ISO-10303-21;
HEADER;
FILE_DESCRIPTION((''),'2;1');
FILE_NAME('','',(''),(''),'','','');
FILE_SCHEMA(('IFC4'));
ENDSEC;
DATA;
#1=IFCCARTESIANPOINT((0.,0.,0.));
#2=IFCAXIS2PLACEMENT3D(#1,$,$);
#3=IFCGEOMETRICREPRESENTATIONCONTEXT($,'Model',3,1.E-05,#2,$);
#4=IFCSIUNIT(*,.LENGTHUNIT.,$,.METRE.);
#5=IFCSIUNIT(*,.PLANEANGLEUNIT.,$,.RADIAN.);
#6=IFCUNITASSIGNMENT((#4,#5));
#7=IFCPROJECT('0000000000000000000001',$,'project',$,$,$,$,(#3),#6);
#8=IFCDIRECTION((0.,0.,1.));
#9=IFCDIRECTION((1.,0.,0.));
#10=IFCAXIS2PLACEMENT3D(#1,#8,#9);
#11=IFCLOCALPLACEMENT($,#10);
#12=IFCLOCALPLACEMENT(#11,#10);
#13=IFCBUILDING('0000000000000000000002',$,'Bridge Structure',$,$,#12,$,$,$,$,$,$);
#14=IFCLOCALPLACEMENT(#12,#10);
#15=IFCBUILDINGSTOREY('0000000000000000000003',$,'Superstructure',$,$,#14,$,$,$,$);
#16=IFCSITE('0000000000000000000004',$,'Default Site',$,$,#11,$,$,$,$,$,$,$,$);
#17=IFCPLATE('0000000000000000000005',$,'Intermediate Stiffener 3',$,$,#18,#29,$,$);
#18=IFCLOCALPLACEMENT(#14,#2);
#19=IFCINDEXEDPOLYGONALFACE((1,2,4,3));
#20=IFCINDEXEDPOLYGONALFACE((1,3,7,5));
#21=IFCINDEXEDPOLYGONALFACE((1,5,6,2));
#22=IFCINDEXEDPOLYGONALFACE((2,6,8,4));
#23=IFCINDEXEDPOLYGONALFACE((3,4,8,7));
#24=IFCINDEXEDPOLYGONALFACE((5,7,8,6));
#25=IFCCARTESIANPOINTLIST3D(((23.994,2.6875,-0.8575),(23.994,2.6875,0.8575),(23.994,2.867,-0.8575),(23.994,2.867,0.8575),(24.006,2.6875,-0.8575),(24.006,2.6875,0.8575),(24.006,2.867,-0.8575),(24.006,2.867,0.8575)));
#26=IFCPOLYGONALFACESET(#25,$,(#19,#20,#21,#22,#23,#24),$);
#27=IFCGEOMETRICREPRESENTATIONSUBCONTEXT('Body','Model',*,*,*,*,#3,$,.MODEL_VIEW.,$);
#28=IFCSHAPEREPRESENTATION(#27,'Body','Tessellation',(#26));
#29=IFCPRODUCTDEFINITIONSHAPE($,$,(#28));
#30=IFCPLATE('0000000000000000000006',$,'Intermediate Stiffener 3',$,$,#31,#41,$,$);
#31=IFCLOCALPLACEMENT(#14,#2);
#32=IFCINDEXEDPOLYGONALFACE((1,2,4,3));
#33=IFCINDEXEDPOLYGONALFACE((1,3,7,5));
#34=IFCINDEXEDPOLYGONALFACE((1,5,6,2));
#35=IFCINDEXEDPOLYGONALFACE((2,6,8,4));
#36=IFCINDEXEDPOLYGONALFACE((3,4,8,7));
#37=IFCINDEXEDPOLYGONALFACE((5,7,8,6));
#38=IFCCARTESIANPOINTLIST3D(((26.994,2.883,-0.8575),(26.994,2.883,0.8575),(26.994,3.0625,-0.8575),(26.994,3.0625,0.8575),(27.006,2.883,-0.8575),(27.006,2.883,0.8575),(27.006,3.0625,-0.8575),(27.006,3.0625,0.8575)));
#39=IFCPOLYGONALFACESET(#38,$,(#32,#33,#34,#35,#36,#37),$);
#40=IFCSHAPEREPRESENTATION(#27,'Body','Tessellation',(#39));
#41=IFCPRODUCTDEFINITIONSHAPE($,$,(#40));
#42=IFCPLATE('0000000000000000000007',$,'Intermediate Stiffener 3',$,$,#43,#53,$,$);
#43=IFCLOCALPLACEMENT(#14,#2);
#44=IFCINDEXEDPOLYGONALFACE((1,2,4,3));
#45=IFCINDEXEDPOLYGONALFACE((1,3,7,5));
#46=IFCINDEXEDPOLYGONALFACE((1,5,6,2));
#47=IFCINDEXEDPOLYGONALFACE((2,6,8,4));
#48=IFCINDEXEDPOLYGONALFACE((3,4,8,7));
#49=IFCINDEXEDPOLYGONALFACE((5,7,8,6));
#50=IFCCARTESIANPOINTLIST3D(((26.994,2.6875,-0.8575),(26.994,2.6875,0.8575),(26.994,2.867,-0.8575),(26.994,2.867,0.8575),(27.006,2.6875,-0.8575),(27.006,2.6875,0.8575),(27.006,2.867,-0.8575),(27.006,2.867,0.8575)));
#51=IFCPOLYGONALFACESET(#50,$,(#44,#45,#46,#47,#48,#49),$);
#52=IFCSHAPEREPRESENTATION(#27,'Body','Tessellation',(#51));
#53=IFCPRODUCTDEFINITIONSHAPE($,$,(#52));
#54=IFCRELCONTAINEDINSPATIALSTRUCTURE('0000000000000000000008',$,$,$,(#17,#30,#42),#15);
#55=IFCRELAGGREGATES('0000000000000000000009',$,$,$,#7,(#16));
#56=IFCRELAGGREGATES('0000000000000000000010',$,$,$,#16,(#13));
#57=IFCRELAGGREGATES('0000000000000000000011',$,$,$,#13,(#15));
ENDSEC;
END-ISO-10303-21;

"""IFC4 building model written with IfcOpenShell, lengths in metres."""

from ifc_helpers import new_model, si_unit, frame, origin, origin_with_axes, origin_2d_with_axis, place, context, subcontext, project, spatial, rectangle, extrude, element, save


model = new_model("IFC4")

# Units and contexts
model_context = context("Model", 3, precision=1e-05, world=origin())
body_context = subcontext(model_context, "Body", "Model", "MODEL_VIEW")
ifc_project = project(units=[si_unit("LENGTHUNIT", "METRE"), si_unit("PLANEANGLEUNIT", "RADIAN")], contexts=[model_context])

# Site, building, storey
site_placement = place(None, origin_with_axes())
site = spatial("IfcSite", under=ifc_project, at=site_placement, Name="Default Site")
building_placement = place(site_placement, origin_with_axes())
building = spatial("IfcBuilding", under=site, at=building_placement, Name="Bridge Structure")
storey_placement = place(building_placement, origin_with_axes())
storey = spatial("IfcBuildingStorey", under=building, at=storey_placement, Name="Superstructure")

# Plates
for number, where, z_axis, x_axis, name in (
    (1, (24.0, 2.7772, -0.8575), (0.0, 0.0, 1.0), (1.0, 0.0, 0.0), "Intermediate Stiffener 3"),
    (2, (27.0, 2.9728, -0.8575), (0.0, 0.0, 1.0), (1.0, 0.0, 0.0), "Intermediate Stiffener 3"),
    (3, (27.0, 2.7772, -0.8575), (0.0, 0.0, 1.0), (1.0, 0.0, 0.0), "Intermediate Stiffener 3"),
):
    element("IfcPlate", number, at=place(storey_placement, frame(where, z_axis=z_axis, x_axis=x_axis)), inside=storey, Name=name, context=body_context, shape_type="SweptSolid", body=[
        extrude(rectangle(XDim=0.012, YDim=0.1795, at=origin_2d_with_axis()), origin_with_axes(), (0.0, 0.0, 1.0), 1.715),
    ])

save(model, "model.ifc")
